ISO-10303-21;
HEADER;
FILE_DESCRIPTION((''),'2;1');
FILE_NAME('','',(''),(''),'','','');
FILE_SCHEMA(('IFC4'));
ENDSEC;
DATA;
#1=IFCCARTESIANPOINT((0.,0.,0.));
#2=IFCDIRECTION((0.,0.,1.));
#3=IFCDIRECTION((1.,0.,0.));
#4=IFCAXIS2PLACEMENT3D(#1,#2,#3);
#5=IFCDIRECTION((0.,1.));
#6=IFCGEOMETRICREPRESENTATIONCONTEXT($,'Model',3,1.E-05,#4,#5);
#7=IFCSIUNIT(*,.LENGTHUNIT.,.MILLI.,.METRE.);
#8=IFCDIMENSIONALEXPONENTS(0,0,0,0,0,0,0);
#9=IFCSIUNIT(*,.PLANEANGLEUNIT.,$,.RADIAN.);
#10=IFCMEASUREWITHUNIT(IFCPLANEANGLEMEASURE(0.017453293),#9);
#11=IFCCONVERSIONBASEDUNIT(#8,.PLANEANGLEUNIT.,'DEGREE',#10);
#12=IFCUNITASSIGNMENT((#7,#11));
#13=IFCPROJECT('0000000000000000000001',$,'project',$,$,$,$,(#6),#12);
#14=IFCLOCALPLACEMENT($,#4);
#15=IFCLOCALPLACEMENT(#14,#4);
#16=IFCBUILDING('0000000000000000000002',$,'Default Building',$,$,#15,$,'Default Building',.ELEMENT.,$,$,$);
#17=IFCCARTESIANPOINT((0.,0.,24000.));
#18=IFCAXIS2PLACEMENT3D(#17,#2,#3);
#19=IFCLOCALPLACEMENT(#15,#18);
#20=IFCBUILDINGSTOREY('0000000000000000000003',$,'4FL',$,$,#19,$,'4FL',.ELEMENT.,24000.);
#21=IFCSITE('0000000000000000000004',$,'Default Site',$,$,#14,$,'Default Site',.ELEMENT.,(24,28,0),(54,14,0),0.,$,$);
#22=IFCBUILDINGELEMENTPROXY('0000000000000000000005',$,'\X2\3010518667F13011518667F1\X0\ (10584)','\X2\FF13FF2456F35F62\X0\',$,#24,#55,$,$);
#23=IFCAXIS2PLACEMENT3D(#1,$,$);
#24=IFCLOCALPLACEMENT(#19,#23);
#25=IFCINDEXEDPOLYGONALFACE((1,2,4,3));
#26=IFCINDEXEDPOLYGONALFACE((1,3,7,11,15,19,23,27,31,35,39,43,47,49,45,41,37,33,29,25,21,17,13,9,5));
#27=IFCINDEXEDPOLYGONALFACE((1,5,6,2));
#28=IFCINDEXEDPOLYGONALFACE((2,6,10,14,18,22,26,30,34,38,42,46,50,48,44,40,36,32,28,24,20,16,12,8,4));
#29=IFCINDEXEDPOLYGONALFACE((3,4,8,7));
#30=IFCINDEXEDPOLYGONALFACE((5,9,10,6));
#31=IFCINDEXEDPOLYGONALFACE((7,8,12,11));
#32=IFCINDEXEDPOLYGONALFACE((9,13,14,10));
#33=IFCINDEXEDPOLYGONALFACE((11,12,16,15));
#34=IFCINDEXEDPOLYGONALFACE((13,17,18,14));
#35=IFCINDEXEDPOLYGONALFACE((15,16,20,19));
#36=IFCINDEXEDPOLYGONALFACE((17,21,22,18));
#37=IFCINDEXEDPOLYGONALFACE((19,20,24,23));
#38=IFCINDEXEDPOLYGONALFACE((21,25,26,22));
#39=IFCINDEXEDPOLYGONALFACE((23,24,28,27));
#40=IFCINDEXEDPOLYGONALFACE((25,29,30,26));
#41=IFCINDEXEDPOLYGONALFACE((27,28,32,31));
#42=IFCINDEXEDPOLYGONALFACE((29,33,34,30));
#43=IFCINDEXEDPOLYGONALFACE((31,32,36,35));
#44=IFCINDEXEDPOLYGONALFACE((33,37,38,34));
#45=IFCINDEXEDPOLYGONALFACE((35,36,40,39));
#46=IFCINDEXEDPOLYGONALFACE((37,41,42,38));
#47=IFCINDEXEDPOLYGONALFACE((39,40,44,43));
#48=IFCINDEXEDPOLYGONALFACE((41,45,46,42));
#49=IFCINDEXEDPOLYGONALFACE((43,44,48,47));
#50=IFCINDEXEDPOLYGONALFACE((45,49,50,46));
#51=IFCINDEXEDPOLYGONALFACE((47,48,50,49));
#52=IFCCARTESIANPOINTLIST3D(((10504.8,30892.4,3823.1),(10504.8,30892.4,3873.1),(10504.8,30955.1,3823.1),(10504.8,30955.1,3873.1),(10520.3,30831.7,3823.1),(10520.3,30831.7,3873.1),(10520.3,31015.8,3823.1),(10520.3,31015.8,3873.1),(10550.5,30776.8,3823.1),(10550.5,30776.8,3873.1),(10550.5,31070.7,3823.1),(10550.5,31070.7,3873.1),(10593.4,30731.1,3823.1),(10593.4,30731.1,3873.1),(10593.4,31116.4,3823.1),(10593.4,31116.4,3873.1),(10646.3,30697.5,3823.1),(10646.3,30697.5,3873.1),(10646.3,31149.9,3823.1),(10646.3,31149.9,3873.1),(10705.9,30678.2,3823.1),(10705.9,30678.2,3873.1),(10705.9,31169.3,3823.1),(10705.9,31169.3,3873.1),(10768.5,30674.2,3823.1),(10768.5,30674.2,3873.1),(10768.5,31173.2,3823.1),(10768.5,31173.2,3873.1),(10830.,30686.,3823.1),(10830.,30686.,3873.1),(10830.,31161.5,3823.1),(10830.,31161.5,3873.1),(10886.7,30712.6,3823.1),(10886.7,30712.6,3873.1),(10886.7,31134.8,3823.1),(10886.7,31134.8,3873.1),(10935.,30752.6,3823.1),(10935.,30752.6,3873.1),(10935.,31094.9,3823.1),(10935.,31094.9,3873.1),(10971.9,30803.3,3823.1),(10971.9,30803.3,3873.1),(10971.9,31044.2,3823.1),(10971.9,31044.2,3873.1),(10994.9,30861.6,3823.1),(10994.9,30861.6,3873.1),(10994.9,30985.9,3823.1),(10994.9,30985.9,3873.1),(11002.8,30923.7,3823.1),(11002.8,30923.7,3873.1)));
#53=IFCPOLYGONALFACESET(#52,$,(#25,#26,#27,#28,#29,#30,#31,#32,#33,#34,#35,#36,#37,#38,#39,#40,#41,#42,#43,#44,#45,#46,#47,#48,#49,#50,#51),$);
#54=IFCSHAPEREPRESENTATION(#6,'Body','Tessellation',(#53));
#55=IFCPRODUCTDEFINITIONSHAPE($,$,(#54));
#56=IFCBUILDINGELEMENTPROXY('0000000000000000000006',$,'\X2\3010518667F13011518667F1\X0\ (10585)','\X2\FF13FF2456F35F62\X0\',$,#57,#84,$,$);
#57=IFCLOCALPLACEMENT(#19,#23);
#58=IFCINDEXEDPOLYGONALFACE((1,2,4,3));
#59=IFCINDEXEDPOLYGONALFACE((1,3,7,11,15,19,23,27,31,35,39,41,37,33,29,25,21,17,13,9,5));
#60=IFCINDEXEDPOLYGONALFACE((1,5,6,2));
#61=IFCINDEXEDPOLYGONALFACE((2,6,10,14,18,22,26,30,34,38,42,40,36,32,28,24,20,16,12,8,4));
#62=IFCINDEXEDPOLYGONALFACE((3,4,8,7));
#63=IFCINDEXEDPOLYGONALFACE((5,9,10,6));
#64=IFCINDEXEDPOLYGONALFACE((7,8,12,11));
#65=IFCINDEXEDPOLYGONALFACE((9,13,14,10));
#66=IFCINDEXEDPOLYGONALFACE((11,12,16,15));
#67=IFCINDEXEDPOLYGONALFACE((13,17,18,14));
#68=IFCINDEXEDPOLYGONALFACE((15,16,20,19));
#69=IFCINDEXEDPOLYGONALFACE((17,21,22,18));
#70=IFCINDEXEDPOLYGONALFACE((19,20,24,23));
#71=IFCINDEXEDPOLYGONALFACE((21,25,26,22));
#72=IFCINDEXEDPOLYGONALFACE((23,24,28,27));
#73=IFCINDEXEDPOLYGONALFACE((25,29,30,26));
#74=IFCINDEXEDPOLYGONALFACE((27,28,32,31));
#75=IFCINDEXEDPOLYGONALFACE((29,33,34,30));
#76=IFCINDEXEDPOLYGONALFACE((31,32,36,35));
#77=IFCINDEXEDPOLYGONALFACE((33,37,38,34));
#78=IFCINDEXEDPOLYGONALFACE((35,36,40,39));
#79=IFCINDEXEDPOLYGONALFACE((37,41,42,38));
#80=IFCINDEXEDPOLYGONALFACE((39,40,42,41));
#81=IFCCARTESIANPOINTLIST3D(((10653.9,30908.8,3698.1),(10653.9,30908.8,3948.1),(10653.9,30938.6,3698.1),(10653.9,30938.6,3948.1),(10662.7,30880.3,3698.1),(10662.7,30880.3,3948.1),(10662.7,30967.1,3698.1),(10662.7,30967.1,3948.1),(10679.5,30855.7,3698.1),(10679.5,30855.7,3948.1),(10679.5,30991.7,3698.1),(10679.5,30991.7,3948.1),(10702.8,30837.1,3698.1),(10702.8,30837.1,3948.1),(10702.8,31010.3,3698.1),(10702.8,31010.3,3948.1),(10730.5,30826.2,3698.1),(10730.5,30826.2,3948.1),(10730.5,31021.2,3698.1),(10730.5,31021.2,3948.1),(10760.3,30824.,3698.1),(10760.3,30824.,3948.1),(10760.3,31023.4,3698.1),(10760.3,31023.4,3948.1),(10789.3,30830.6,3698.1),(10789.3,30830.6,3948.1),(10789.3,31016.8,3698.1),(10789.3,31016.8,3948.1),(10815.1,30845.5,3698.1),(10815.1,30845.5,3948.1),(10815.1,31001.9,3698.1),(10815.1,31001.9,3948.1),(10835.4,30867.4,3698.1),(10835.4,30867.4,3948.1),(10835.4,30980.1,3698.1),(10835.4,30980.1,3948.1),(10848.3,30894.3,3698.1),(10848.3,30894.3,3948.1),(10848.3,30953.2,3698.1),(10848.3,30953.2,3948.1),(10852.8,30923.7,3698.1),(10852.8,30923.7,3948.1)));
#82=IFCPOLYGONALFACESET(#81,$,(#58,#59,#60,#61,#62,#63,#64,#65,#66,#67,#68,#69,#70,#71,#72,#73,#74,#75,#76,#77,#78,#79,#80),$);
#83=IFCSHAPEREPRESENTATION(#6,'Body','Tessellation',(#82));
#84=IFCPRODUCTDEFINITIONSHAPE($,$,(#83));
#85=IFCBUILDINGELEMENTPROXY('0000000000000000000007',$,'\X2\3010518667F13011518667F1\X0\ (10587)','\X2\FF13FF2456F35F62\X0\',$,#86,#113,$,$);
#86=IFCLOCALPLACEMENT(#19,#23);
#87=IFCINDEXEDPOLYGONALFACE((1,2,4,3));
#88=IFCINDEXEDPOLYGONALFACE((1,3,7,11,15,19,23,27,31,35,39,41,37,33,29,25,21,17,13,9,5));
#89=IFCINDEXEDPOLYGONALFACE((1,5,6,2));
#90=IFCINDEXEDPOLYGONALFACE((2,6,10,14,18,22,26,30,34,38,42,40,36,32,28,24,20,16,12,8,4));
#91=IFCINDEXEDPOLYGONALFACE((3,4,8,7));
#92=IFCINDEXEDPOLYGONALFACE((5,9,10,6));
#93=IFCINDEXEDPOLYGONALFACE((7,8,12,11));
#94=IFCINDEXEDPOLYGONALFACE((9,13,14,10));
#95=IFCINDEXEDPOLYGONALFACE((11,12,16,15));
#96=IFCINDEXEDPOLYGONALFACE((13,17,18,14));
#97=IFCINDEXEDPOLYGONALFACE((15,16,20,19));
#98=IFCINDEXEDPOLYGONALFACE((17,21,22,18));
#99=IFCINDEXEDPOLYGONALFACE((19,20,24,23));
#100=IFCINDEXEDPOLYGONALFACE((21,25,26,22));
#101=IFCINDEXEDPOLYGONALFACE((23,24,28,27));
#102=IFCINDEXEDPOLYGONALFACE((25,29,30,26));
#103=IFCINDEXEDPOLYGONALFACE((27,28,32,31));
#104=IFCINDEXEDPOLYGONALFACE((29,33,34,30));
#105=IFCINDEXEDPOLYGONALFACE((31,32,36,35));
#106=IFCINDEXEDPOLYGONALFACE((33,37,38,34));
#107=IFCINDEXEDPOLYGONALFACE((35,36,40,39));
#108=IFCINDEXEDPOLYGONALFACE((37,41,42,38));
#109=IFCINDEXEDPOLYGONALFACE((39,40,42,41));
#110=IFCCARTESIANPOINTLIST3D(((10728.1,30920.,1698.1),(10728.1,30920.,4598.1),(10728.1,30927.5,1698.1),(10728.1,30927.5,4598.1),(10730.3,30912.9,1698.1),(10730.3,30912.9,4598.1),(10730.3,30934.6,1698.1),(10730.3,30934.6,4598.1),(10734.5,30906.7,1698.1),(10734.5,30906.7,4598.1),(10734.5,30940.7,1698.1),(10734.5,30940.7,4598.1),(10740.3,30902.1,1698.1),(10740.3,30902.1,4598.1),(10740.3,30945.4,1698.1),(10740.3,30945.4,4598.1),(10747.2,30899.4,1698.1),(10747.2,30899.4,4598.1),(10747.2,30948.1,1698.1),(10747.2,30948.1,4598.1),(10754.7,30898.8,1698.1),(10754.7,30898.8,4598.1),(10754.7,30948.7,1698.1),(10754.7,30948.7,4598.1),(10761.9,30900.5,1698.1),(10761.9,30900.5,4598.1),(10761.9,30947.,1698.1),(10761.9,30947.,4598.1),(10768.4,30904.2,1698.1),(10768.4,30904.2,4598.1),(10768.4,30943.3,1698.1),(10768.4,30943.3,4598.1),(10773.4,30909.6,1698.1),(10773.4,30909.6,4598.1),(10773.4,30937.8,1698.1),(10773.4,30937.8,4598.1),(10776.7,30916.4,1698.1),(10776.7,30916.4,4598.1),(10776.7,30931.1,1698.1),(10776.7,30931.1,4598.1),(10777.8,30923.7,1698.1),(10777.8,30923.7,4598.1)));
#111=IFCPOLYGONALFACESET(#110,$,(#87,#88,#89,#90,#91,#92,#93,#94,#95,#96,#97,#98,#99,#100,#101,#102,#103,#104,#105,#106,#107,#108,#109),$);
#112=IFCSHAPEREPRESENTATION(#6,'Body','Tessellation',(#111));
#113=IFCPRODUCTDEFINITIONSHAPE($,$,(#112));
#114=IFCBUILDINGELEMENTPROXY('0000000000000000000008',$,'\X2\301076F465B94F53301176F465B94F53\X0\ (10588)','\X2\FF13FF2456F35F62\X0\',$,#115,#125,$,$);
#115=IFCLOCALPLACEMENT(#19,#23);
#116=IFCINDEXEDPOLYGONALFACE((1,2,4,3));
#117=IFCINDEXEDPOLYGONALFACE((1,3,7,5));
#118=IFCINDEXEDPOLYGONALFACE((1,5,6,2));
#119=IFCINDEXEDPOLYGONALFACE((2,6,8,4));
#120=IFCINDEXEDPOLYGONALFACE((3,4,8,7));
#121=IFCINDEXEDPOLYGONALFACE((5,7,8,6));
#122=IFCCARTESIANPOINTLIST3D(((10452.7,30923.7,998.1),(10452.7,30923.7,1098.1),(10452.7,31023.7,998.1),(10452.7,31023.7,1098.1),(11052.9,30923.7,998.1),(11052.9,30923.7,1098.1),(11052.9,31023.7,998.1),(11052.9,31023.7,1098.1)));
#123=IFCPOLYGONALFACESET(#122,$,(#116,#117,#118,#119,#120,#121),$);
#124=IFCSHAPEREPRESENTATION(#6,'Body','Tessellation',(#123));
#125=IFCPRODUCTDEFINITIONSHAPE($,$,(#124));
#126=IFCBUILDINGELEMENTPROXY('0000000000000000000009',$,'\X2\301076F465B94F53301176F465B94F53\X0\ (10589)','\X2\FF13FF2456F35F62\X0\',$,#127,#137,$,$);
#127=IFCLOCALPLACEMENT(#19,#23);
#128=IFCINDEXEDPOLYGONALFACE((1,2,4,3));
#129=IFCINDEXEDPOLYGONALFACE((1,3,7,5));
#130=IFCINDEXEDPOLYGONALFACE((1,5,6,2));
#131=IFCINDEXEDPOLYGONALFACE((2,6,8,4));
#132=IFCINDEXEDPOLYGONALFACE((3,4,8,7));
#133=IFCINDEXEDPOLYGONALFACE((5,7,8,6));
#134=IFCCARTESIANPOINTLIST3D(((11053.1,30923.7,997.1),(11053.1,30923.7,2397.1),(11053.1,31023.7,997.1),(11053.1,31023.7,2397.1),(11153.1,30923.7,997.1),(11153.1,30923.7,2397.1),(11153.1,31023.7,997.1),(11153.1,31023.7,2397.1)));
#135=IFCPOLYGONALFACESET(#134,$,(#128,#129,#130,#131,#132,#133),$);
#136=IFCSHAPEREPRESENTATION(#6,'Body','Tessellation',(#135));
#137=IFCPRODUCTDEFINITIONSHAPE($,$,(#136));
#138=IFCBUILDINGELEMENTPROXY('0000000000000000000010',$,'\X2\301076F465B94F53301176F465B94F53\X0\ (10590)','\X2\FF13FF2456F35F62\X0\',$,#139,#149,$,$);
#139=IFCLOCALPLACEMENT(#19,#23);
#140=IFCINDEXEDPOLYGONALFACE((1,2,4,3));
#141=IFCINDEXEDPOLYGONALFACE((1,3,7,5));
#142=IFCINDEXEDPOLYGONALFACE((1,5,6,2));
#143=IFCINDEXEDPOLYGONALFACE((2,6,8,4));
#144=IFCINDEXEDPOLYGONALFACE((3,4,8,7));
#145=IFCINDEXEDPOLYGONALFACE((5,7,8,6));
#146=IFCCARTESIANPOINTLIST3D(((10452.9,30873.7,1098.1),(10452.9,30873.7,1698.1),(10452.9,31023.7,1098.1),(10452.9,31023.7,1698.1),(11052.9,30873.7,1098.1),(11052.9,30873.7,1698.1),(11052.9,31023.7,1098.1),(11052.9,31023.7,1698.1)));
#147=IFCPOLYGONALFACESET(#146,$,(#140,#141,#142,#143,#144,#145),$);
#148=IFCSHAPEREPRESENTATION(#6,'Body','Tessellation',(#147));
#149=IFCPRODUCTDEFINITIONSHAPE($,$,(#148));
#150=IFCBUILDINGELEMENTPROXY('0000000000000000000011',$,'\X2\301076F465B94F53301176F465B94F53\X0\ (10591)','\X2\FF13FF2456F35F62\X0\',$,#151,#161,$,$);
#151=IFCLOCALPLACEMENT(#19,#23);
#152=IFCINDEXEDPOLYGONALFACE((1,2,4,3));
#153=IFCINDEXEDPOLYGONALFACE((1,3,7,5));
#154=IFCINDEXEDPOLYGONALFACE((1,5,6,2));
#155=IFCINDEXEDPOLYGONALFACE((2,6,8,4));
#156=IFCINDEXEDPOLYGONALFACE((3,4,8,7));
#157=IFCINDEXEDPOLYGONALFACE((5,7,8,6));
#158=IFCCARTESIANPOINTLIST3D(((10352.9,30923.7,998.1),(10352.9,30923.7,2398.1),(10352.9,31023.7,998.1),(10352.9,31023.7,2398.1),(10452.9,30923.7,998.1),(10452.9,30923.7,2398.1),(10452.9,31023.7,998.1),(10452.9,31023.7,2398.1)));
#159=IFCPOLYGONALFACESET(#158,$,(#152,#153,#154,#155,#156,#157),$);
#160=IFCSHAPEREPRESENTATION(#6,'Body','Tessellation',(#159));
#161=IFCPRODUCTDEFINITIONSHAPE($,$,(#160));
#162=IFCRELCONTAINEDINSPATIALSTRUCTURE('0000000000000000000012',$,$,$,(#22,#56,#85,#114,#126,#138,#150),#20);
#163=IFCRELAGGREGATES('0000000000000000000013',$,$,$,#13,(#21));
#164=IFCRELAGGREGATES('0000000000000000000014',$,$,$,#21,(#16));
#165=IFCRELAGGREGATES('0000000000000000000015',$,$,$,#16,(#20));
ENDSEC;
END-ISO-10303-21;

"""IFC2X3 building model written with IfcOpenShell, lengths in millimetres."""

from ifc_helpers import new_model, entity, si_unit, converted_unit, direction, frame, origin_with_axes, origin_2d_with_axis, place, context, project, spatial, rectangle, circle, extrude, source, transform, mapped, element, save


model = new_model("IFC2X3")

# Units and contexts
model_context = context("Model", 3, precision=1e-05, world=origin_with_axes(), true_north=direction((0.0, 1.0)))
ifc_project = project(units=[si_unit("LENGTHUNIT", "METRE", prefix="MILLI"), converted_unit("PLANEANGLEUNIT", "DEGREE", entity("IfcPlaneAngleMeasure", 0.017453293), si_unit("PLANEANGLEUNIT", "RADIAN"), dimensions=[0, 0, 0, 0, 0, 0, 0])], contexts=[model_context])

# Site, building, storey
site_placement = place(None, origin_with_axes())
site = spatial("IfcSite", under=ifc_project, at=site_placement, Name="Default Site", LongName="Default Site", CompositionType="ELEMENT", RefLatitude=(24, 28, 0), RefLongitude=(54, 14, 0), RefElevation=0.0)
building_placement = place(site_placement, origin_with_axes())
building = spatial("IfcBuilding", under=site, at=building_placement, Name="Default Building", LongName="Default Building", CompositionType="ELEMENT")
storey_placement = place(building_placement, frame((0.0, 0.0, 24000.0), z_axis=(0.0, 0.0, 1.0), x_axis=(1.0, 0.0, 0.0)))
storey = spatial("IfcBuildingStorey", under=building, at=storey_placement, Name="4FL", LongName="4FL", CompositionType="ELEMENT", Elevation=24000.0)

# Building element proxies
shared_shape_1 = source(origin_with_axes(), model_context, "Body", "SweptSolid", [
    extrude(circle(Radius=250.0, at=origin_2d_with_axis()), origin_with_axes(), (0.0, 0.0, 1.0), 50.0),
])
proxy_1_placement = place(storey_placement, frame((10752.8, 30923.7, 3823.1), z_axis=(0.0, 0.0, 1.0), x_axis=(1.0, 0.0, 0.0)))
element("IfcBuildingElementProxy", 1, at=proxy_1_placement, inside=storey, Name="【円柱】円柱 (10584)", Description="３Ｄ図形", context=model_context, shape_type="MappedRepresentation", body=[
    mapped(shared_shape_1, transform((0.0, 0.0, 0.0))),
])
shared_shape_2 = source(origin_with_axes(), model_context, "Body", "SweptSolid", [
    extrude(circle(Radius=100.0, at=origin_2d_with_axis()), origin_with_axes(), (0.0, 0.0, 1.0), 250.0),
])
proxy_2_placement = place(storey_placement, frame((10752.8, 30923.7, 3698.1), z_axis=(0.0, 0.0, 1.0), x_axis=(1.0, 0.0, 0.0)))
element("IfcBuildingElementProxy", 2, at=proxy_2_placement, inside=storey, Name="【円柱】円柱 (10585)", Description="３Ｄ図形", context=model_context, shape_type="MappedRepresentation", body=[
    mapped(shared_shape_2, transform((0.0, 0.0, 0.0))),
])
shared_shape_3 = source(origin_with_axes(), model_context, "Body", "SweptSolid", [
    extrude(circle(Radius=25.0, at=origin_2d_with_axis()), origin_with_axes(), (0.0, 0.0, 1.0), 2900.0),
])
proxy_3_placement = place(storey_placement, frame((10752.8, 30923.7, 1698.1), z_axis=(0.0, 0.0, 1.0), x_axis=(1.0, 0.0, 0.0)))
element("IfcBuildingElementProxy", 3, at=proxy_3_placement, inside=storey, Name="【円柱】円柱 (10587)", Description="３Ｄ図形", context=model_context, shape_type="MappedRepresentation", body=[
    mapped(shared_shape_3, transform((0.0, 0.0, 0.0))),
])
shared_shape_4 = source(origin_with_axes(), model_context, "Body", "SweptSolid", [
    extrude(rectangle(XDim=600.2, YDim=100.0, at=origin_2d_with_axis()), origin_with_axes(), (0.0, 0.0, 1.0), 100.0),
])
proxy_4_placement = place(storey_placement, frame((10752.8, 30973.7, 998.1), z_axis=(0.0, 0.0, 1.0), x_axis=(1.0, 0.0, 0.0)))
element("IfcBuildingElementProxy", 4, at=proxy_4_placement, inside=storey, Name="【直方体】直方体 (10588)", Description="３Ｄ図形", context=model_context, shape_type="MappedRepresentation", body=[
    mapped(shared_shape_4, transform((0.0, 0.0, 0.0))),
])
shared_shape_5 = source(origin_with_axes(), model_context, "Body", "SweptSolid", [
    extrude(rectangle(XDim=100.0, YDim=100.0, at=origin_2d_with_axis()), origin_with_axes(), (0.0, 0.0, 1.0), 1400.0),
])
proxy_5_placement = place(storey_placement, frame((11103.1, 30973.7, 997.1), z_axis=(0.0, 0.0, 1.0), x_axis=(1.0, 0.0, 0.0)))
element("IfcBuildingElementProxy", 5, at=proxy_5_placement, inside=storey, Name="【直方体】直方体 (10589)", Description="３Ｄ図形", context=model_context, shape_type="MappedRepresentation", body=[
    mapped(shared_shape_5, transform((0.0, 0.0, 0.0))),
])
shared_shape_6 = source(origin_with_axes(), model_context, "Body", "SweptSolid", [
    extrude(rectangle(XDim=600.0, YDim=150.0, at=origin_2d_with_axis()), origin_with_axes(), (0.0, 0.0, 1.0), 600.0),
])
proxy_6_placement = place(storey_placement, frame((10752.9, 30948.7, 1098.1), z_axis=(0.0, 0.0, 1.0), x_axis=(1.0, 0.0, 0.0)))
element("IfcBuildingElementProxy", 6, at=proxy_6_placement, inside=storey, Name="【直方体】直方体 (10590)", Description="３Ｄ図形", context=model_context, shape_type="MappedRepresentation", body=[
    mapped(shared_shape_6, transform((0.0, 0.0, 0.0))),
])
shared_shape_7 = source(origin_with_axes(), model_context, "Body", "SweptSolid", [
    extrude(rectangle(XDim=100.0, YDim=100.0, at=origin_2d_with_axis()), origin_with_axes(), (0.0, 0.0, 1.0), 1400.0),
])
proxy_7_placement = place(storey_placement, frame((10402.9, 30973.7, 998.1), z_axis=(0.0, 0.0, 1.0), x_axis=(1.0, 0.0, 0.0)))
element("IfcBuildingElementProxy", 7, at=proxy_7_placement, inside=storey, Name="【直方体】直方体 (10591)", Description="３Ｄ図形", context=model_context, shape_type="MappedRepresentation", body=[
    mapped(shared_shape_7, transform((0.0, 0.0, 0.0))),
])

save(model, "model.ifc")
